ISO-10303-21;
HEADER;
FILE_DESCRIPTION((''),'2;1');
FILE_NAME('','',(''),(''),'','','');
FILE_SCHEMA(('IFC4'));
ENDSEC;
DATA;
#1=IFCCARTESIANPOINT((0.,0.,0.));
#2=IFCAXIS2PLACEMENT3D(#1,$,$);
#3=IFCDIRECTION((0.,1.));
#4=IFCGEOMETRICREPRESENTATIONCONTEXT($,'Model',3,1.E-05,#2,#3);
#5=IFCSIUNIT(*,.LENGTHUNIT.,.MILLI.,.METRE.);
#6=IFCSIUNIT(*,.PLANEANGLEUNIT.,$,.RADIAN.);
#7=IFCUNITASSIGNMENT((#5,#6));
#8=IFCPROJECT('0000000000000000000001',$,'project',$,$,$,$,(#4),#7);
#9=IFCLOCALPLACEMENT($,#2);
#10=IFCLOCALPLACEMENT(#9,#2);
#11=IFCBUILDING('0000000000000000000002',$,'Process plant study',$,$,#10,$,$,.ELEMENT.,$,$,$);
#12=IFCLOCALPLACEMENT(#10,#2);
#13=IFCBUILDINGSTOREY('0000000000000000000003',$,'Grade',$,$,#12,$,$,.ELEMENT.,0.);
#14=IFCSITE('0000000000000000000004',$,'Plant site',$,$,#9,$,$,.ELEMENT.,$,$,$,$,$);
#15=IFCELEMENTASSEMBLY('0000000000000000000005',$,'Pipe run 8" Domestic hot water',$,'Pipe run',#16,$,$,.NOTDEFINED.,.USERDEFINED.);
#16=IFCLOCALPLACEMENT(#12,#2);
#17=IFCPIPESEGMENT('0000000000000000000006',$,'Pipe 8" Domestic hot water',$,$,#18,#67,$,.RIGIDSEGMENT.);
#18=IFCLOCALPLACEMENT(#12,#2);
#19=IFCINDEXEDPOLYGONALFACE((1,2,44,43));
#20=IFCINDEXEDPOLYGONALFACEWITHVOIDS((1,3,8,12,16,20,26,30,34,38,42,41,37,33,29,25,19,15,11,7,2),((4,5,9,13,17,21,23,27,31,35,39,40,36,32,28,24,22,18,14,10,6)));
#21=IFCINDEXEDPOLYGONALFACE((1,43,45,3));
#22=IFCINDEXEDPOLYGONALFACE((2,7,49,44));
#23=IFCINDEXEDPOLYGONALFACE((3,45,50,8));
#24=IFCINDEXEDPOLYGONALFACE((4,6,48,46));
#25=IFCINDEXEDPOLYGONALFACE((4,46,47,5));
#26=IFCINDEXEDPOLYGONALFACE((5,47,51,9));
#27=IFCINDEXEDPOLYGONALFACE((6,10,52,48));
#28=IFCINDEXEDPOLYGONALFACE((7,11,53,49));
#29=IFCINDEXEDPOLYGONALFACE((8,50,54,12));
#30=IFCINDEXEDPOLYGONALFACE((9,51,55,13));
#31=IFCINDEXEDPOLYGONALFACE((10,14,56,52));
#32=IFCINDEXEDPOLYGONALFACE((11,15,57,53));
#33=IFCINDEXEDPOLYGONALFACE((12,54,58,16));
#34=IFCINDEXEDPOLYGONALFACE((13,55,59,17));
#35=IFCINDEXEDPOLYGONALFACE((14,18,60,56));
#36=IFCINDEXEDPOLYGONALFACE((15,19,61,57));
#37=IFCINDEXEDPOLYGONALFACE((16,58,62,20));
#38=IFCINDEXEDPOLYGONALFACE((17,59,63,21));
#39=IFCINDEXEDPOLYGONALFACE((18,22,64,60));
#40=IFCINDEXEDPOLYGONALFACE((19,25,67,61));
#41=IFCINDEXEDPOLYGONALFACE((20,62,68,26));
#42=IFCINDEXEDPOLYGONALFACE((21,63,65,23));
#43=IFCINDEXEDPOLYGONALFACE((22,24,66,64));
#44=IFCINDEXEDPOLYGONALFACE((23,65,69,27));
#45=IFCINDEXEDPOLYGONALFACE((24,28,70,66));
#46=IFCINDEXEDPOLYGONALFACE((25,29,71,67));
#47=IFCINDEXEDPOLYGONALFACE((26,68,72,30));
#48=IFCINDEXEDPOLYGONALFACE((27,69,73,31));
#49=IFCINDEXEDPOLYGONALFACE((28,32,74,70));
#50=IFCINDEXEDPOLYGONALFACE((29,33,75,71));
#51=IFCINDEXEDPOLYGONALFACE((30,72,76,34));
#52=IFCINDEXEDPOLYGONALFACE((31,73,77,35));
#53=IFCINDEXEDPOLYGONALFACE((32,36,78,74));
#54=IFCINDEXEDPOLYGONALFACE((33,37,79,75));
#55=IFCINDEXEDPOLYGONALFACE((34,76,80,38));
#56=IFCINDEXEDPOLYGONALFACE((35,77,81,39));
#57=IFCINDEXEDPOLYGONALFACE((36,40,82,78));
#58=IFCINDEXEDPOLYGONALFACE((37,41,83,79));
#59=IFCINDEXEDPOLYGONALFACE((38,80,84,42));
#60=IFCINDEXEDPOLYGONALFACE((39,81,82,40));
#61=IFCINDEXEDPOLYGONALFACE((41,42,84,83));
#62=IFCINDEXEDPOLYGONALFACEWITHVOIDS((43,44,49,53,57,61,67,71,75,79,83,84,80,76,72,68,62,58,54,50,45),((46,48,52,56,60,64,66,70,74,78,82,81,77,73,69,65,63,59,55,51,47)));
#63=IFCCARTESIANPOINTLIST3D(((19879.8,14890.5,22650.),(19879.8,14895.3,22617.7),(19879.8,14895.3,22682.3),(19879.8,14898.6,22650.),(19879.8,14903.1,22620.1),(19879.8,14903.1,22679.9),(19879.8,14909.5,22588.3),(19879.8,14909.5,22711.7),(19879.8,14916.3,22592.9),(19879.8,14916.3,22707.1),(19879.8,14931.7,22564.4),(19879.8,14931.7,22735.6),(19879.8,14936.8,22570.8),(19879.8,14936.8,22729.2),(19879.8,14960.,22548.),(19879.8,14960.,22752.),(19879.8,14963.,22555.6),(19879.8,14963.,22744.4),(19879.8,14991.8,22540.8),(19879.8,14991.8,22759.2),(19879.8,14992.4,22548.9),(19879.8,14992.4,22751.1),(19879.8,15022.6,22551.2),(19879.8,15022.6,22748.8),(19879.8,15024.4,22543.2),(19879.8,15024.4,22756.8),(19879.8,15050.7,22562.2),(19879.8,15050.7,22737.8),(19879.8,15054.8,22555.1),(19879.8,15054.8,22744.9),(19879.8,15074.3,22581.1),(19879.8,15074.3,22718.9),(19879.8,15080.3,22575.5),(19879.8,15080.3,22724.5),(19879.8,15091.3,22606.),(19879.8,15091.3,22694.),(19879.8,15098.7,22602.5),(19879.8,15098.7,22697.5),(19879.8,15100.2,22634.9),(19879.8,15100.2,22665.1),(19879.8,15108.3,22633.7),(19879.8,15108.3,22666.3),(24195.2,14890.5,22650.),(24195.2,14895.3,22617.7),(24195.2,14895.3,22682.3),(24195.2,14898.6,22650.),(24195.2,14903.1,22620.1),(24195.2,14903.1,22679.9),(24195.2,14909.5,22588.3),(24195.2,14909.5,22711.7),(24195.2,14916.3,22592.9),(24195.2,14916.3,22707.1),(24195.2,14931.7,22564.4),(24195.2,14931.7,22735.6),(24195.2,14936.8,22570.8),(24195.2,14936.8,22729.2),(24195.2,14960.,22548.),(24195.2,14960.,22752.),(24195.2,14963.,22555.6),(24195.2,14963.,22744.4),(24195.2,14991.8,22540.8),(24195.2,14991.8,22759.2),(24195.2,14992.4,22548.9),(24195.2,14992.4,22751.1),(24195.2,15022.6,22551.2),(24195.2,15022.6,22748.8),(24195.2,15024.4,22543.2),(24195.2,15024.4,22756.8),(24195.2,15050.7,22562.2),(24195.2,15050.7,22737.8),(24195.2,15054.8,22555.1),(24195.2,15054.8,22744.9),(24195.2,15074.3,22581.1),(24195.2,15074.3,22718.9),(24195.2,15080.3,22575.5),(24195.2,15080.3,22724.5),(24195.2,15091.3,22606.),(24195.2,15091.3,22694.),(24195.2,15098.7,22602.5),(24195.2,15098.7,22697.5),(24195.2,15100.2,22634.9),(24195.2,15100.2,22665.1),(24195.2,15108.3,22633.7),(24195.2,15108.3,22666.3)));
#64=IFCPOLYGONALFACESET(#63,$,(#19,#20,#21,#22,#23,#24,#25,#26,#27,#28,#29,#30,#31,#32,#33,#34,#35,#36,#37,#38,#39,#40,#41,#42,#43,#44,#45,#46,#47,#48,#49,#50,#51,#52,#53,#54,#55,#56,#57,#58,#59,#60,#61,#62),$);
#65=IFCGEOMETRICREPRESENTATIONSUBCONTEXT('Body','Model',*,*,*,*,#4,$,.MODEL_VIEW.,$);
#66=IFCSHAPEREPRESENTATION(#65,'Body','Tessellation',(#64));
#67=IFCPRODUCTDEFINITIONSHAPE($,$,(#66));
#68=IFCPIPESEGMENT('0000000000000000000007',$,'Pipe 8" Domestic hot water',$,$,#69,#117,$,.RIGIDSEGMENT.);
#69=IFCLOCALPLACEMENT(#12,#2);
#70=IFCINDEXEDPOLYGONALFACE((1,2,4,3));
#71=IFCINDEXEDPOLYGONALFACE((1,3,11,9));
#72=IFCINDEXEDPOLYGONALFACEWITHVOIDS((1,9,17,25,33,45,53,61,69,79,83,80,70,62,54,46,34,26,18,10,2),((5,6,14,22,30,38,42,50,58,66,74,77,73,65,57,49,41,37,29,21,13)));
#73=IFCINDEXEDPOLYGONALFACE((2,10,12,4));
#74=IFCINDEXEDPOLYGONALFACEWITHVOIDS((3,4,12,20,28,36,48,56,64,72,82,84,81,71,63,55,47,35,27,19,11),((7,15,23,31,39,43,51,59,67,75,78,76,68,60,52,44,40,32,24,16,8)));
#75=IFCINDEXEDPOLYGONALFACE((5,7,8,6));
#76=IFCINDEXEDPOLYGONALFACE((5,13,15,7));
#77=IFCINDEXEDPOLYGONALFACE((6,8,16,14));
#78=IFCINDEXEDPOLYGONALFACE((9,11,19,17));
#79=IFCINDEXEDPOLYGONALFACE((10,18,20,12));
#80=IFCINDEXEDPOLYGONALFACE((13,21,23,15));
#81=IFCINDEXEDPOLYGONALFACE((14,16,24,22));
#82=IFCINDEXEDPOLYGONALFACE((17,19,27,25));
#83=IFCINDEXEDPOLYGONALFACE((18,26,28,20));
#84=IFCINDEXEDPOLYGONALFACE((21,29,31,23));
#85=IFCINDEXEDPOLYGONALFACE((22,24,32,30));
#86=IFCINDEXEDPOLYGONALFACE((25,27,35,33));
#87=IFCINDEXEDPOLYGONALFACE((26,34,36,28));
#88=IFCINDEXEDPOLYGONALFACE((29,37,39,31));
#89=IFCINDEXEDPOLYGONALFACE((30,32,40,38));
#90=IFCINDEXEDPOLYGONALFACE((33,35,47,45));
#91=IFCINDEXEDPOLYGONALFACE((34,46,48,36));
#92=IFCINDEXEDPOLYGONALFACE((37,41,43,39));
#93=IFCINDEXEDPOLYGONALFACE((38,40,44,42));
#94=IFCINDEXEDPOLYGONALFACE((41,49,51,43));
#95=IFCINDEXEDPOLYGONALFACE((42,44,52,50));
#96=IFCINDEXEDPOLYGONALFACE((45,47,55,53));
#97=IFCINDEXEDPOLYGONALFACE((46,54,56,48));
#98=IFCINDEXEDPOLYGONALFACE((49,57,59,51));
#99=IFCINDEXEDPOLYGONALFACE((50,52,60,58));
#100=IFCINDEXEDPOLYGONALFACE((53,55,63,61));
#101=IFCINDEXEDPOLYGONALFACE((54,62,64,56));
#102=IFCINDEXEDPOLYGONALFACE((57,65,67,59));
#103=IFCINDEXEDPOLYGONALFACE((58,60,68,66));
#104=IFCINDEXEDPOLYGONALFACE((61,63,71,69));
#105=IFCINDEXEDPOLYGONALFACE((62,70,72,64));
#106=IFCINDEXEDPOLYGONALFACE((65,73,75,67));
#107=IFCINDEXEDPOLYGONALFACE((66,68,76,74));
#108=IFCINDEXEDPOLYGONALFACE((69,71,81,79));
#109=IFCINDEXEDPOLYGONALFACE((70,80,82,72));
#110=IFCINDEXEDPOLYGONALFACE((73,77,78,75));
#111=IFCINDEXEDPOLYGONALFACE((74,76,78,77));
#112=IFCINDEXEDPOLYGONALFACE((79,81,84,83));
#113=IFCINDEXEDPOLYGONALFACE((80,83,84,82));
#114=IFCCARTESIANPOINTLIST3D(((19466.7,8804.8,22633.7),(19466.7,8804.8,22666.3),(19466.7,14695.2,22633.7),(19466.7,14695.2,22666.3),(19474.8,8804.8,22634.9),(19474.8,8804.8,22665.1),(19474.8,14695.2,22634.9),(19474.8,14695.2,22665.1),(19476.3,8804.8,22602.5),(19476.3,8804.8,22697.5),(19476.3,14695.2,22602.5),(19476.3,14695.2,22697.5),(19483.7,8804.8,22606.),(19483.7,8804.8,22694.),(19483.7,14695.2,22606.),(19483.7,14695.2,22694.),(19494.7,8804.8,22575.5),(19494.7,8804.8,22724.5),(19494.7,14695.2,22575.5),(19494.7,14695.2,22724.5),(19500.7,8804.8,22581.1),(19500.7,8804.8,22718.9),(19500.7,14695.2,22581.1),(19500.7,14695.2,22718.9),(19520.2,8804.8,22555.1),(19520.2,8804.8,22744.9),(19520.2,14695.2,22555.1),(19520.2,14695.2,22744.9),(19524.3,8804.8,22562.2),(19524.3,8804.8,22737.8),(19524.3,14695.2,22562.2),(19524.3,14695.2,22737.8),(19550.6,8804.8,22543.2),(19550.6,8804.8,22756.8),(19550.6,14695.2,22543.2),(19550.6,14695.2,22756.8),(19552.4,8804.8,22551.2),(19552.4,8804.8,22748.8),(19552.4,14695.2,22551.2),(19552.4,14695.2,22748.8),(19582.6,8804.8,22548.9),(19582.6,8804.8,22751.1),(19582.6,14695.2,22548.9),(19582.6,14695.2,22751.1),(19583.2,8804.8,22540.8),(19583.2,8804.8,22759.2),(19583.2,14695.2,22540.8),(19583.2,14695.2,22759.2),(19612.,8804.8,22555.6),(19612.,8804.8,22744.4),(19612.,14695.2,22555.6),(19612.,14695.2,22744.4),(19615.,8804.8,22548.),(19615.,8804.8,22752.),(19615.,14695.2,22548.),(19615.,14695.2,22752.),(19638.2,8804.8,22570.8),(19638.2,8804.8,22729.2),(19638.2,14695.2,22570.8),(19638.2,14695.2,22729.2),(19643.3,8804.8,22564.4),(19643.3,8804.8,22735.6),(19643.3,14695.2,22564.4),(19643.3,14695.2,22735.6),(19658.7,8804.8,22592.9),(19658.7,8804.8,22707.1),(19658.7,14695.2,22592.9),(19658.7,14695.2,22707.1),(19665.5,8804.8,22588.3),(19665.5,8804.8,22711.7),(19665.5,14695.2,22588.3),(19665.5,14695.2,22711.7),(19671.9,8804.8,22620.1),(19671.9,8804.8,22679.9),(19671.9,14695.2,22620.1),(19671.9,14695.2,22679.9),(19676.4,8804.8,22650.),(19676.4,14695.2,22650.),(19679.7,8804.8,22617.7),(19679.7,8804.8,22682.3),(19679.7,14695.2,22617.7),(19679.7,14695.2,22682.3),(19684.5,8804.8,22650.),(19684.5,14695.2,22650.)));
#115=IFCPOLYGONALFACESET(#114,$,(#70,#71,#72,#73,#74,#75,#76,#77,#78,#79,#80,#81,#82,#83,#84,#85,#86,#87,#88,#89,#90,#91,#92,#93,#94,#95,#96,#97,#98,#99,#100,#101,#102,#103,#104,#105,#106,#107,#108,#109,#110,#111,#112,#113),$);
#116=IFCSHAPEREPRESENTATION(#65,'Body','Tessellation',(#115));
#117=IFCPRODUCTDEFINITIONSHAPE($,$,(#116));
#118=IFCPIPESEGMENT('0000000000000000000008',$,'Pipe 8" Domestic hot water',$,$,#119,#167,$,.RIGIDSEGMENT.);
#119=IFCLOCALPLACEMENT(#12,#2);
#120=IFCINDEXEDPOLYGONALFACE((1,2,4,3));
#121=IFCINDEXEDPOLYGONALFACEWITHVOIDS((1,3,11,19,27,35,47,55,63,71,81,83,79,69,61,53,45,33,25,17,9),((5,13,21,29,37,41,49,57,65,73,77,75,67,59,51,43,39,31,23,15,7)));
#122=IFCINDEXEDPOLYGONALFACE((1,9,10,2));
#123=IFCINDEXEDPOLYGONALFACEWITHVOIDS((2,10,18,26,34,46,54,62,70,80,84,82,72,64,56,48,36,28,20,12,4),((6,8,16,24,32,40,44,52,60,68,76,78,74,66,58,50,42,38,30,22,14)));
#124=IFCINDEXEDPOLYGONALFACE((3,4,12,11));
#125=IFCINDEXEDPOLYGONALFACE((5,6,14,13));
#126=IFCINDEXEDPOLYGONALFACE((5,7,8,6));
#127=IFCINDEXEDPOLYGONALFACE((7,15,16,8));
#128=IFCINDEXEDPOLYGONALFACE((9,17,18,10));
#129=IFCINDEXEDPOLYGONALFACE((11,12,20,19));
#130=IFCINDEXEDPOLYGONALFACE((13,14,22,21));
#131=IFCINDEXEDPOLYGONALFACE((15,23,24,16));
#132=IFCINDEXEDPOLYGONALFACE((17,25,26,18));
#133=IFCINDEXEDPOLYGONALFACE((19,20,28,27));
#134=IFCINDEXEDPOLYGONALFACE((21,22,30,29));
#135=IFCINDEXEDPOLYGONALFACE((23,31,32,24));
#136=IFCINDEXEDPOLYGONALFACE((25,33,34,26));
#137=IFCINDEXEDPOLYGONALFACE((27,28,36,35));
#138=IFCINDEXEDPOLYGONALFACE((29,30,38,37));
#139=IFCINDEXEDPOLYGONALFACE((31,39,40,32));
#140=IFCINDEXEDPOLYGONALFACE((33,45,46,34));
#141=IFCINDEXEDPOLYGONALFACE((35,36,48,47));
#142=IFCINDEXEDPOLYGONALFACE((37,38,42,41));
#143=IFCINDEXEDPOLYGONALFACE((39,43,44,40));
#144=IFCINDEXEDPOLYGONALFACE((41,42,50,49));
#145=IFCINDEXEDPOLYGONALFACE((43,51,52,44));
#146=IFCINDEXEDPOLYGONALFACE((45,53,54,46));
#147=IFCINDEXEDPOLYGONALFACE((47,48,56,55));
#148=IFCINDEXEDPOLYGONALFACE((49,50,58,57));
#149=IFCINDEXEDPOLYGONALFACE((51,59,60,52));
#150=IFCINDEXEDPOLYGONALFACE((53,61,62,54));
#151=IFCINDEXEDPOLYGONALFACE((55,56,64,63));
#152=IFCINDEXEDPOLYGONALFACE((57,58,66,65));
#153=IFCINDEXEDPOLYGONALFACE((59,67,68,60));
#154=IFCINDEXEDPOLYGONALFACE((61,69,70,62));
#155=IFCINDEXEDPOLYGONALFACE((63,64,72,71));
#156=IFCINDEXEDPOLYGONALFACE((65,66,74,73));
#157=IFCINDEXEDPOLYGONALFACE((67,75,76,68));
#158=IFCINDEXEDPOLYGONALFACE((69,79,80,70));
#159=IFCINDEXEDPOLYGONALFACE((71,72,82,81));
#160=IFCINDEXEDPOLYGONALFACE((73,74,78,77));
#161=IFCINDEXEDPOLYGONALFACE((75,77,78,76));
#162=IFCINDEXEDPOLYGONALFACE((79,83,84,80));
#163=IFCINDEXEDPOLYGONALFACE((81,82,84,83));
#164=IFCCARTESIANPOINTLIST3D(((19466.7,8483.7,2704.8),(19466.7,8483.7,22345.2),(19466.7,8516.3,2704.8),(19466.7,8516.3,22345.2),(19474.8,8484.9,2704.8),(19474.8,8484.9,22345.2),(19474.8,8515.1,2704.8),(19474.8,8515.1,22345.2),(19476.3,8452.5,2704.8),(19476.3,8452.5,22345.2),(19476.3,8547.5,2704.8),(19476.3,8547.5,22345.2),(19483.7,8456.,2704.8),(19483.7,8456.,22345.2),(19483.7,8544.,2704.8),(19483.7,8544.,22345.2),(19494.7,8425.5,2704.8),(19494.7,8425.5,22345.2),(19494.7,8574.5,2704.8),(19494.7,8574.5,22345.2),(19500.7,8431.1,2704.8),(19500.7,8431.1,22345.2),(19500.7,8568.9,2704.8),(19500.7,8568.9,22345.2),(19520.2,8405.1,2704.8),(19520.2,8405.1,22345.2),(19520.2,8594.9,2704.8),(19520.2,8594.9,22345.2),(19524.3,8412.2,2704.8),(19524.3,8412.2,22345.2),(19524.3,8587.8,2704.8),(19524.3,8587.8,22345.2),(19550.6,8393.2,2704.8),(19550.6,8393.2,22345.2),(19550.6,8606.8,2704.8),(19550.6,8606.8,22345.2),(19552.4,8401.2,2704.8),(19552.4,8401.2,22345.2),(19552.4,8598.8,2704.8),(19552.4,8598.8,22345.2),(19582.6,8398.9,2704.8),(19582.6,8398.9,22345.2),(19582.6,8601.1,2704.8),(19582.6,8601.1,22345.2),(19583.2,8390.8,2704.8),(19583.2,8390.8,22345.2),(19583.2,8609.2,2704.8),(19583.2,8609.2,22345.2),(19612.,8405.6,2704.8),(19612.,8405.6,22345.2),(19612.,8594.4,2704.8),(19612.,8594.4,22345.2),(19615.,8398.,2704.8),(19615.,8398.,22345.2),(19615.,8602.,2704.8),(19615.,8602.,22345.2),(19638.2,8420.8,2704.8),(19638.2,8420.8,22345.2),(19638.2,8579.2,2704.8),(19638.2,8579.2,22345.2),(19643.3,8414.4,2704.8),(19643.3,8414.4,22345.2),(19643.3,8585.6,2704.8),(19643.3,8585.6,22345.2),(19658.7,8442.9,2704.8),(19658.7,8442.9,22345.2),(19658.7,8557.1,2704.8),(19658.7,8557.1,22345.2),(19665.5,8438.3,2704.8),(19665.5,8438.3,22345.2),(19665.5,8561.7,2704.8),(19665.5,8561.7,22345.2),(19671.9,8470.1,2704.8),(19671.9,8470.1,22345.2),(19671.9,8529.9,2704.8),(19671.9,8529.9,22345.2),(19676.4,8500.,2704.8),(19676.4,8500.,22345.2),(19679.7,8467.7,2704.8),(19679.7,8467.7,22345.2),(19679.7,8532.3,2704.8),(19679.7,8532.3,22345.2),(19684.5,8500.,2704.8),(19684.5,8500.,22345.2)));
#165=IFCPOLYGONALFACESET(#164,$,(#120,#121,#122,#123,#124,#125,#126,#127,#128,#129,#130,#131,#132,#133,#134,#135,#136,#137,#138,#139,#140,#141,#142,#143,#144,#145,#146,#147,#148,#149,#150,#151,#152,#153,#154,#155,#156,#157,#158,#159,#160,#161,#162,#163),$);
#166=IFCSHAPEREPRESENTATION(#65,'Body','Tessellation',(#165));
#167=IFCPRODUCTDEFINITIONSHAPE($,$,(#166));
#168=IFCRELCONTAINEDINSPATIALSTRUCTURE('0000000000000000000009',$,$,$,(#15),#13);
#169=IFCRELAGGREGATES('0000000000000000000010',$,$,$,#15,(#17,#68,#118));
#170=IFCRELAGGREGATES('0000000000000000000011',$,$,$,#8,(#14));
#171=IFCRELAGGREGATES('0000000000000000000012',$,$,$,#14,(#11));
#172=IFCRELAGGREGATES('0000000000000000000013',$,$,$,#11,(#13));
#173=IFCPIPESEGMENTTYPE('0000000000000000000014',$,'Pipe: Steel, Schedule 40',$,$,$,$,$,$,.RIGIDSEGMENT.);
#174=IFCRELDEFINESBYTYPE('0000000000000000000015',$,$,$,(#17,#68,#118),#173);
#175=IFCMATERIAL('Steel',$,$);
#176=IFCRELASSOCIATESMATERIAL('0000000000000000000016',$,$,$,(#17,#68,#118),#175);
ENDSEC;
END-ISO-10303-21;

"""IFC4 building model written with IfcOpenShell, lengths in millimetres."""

from ifc_helpers import new_model, si_unit, direction, frame, origin, origin_with_axes, origin_2d, place, context, subcontext, project, spatial, hollow_circle, extrude, material, type_object, element, aggregate, save


model = new_model("IFC4")

# Units and contexts
model_context = context("Model", 3, precision=1e-05, world=origin(), true_north=direction((0.0, 1.0)))
body_context = subcontext(model_context, "Body", "Model", "MODEL_VIEW")
ifc_project = project(units=[si_unit("LENGTHUNIT", "METRE", prefix="MILLI"), si_unit("PLANEANGLEUNIT", "RADIAN")], contexts=[model_context])

# Site, building, storey
site_placement = place(None, origin())
site = spatial("IfcSite", under=ifc_project, at=site_placement, Name="Plant site", CompositionType="ELEMENT")
building_placement = place(site_placement, origin())
building = spatial("IfcBuilding", under=site, at=building_placement, Name="Process plant study", CompositionType="ELEMENT")
storey_placement = place(building_placement, origin())
storey = spatial("IfcBuildingStorey", under=building, at=storey_placement, Name="Grade", CompositionType="ELEMENT", Elevation=0.0)

# Element assembly, pipe segments
assembly_1_placement = place(storey_placement, origin_with_axes())
assembly_1 = element("IfcElementAssembly", 1, at=assembly_1_placement, inside=storey, Name="Pipe run 8\" Domestic hot water", ObjectType="Pipe run", AssemblyPlace="NOTDEFINED", PredefinedType="USERDEFINED")
ifc_material = material(Name="Steel")
pipe_segment_type = type_object("IfcPipeSegmentType", Name="Pipe: Steel, Schedule 40", PredefinedType="RIGIDSEGMENT")
pipe_segment_1_placement = place(storey_placement, origin_with_axes())
pipe_segment_1 = element("IfcPipeSegment", 2, at=pipe_segment_1_placement, type_object=pipe_segment_type, material=ifc_material, Name="Pipe 8\" Domestic hot water", PredefinedType="RIGIDSEGMENT", context=body_context, shape_type="SweptSolid", body=[
    extrude(hollow_circle(Radius=109.5, WallThickness=8.2, at=origin_2d()), frame((24195.2, 15000.0, 22650.0), z_axis=(-1.0, 0.0, 0.0), x_axis=(0.0, -1.0, 0.0)), (0.0, 0.0, 1.0), 4315.4),
])
pipe_segment_2_placement = place(storey_placement, origin_with_axes())
pipe_segment_2 = element("IfcPipeSegment", 3, at=pipe_segment_2_placement, type_object=pipe_segment_type, material=ifc_material, Name="Pipe 8\" Domestic hot water", PredefinedType="RIGIDSEGMENT", context=body_context, shape_type="SweptSolid", body=[
    extrude(hollow_circle(Radius=109.5, WallThickness=8.2, at=origin_2d()), frame((19575.0, 14695.2, 22650.0), z_axis=(0.0, -1.0, 0.0), x_axis=(1.0, 0.0, 0.0)), (0.0, 0.0, 1.0), 5890.4),
])
pipe_segment_3_placement = place(storey_placement, origin_with_axes())
pipe_segment_3 = element("IfcPipeSegment", 4, at=pipe_segment_3_placement, type_object=pipe_segment_type, material=ifc_material, Name="Pipe 8\" Domestic hot water", PredefinedType="RIGIDSEGMENT", context=body_context, shape_type="SweptSolid", body=[
    extrude(hollow_circle(Radius=109.5, WallThickness=8.2, at=origin_2d()), frame((19575.0, 8500.0, 22345.2), z_axis=(0.0, 0.0, -1.0), x_axis=(1.0, 0.0, 0.0)), (0.0, 0.0, 1.0), 19640.4),
])

aggregate(assembly_1, [pipe_segment_1, pipe_segment_2, pipe_segment_3])

save(model, "model.ifc")
